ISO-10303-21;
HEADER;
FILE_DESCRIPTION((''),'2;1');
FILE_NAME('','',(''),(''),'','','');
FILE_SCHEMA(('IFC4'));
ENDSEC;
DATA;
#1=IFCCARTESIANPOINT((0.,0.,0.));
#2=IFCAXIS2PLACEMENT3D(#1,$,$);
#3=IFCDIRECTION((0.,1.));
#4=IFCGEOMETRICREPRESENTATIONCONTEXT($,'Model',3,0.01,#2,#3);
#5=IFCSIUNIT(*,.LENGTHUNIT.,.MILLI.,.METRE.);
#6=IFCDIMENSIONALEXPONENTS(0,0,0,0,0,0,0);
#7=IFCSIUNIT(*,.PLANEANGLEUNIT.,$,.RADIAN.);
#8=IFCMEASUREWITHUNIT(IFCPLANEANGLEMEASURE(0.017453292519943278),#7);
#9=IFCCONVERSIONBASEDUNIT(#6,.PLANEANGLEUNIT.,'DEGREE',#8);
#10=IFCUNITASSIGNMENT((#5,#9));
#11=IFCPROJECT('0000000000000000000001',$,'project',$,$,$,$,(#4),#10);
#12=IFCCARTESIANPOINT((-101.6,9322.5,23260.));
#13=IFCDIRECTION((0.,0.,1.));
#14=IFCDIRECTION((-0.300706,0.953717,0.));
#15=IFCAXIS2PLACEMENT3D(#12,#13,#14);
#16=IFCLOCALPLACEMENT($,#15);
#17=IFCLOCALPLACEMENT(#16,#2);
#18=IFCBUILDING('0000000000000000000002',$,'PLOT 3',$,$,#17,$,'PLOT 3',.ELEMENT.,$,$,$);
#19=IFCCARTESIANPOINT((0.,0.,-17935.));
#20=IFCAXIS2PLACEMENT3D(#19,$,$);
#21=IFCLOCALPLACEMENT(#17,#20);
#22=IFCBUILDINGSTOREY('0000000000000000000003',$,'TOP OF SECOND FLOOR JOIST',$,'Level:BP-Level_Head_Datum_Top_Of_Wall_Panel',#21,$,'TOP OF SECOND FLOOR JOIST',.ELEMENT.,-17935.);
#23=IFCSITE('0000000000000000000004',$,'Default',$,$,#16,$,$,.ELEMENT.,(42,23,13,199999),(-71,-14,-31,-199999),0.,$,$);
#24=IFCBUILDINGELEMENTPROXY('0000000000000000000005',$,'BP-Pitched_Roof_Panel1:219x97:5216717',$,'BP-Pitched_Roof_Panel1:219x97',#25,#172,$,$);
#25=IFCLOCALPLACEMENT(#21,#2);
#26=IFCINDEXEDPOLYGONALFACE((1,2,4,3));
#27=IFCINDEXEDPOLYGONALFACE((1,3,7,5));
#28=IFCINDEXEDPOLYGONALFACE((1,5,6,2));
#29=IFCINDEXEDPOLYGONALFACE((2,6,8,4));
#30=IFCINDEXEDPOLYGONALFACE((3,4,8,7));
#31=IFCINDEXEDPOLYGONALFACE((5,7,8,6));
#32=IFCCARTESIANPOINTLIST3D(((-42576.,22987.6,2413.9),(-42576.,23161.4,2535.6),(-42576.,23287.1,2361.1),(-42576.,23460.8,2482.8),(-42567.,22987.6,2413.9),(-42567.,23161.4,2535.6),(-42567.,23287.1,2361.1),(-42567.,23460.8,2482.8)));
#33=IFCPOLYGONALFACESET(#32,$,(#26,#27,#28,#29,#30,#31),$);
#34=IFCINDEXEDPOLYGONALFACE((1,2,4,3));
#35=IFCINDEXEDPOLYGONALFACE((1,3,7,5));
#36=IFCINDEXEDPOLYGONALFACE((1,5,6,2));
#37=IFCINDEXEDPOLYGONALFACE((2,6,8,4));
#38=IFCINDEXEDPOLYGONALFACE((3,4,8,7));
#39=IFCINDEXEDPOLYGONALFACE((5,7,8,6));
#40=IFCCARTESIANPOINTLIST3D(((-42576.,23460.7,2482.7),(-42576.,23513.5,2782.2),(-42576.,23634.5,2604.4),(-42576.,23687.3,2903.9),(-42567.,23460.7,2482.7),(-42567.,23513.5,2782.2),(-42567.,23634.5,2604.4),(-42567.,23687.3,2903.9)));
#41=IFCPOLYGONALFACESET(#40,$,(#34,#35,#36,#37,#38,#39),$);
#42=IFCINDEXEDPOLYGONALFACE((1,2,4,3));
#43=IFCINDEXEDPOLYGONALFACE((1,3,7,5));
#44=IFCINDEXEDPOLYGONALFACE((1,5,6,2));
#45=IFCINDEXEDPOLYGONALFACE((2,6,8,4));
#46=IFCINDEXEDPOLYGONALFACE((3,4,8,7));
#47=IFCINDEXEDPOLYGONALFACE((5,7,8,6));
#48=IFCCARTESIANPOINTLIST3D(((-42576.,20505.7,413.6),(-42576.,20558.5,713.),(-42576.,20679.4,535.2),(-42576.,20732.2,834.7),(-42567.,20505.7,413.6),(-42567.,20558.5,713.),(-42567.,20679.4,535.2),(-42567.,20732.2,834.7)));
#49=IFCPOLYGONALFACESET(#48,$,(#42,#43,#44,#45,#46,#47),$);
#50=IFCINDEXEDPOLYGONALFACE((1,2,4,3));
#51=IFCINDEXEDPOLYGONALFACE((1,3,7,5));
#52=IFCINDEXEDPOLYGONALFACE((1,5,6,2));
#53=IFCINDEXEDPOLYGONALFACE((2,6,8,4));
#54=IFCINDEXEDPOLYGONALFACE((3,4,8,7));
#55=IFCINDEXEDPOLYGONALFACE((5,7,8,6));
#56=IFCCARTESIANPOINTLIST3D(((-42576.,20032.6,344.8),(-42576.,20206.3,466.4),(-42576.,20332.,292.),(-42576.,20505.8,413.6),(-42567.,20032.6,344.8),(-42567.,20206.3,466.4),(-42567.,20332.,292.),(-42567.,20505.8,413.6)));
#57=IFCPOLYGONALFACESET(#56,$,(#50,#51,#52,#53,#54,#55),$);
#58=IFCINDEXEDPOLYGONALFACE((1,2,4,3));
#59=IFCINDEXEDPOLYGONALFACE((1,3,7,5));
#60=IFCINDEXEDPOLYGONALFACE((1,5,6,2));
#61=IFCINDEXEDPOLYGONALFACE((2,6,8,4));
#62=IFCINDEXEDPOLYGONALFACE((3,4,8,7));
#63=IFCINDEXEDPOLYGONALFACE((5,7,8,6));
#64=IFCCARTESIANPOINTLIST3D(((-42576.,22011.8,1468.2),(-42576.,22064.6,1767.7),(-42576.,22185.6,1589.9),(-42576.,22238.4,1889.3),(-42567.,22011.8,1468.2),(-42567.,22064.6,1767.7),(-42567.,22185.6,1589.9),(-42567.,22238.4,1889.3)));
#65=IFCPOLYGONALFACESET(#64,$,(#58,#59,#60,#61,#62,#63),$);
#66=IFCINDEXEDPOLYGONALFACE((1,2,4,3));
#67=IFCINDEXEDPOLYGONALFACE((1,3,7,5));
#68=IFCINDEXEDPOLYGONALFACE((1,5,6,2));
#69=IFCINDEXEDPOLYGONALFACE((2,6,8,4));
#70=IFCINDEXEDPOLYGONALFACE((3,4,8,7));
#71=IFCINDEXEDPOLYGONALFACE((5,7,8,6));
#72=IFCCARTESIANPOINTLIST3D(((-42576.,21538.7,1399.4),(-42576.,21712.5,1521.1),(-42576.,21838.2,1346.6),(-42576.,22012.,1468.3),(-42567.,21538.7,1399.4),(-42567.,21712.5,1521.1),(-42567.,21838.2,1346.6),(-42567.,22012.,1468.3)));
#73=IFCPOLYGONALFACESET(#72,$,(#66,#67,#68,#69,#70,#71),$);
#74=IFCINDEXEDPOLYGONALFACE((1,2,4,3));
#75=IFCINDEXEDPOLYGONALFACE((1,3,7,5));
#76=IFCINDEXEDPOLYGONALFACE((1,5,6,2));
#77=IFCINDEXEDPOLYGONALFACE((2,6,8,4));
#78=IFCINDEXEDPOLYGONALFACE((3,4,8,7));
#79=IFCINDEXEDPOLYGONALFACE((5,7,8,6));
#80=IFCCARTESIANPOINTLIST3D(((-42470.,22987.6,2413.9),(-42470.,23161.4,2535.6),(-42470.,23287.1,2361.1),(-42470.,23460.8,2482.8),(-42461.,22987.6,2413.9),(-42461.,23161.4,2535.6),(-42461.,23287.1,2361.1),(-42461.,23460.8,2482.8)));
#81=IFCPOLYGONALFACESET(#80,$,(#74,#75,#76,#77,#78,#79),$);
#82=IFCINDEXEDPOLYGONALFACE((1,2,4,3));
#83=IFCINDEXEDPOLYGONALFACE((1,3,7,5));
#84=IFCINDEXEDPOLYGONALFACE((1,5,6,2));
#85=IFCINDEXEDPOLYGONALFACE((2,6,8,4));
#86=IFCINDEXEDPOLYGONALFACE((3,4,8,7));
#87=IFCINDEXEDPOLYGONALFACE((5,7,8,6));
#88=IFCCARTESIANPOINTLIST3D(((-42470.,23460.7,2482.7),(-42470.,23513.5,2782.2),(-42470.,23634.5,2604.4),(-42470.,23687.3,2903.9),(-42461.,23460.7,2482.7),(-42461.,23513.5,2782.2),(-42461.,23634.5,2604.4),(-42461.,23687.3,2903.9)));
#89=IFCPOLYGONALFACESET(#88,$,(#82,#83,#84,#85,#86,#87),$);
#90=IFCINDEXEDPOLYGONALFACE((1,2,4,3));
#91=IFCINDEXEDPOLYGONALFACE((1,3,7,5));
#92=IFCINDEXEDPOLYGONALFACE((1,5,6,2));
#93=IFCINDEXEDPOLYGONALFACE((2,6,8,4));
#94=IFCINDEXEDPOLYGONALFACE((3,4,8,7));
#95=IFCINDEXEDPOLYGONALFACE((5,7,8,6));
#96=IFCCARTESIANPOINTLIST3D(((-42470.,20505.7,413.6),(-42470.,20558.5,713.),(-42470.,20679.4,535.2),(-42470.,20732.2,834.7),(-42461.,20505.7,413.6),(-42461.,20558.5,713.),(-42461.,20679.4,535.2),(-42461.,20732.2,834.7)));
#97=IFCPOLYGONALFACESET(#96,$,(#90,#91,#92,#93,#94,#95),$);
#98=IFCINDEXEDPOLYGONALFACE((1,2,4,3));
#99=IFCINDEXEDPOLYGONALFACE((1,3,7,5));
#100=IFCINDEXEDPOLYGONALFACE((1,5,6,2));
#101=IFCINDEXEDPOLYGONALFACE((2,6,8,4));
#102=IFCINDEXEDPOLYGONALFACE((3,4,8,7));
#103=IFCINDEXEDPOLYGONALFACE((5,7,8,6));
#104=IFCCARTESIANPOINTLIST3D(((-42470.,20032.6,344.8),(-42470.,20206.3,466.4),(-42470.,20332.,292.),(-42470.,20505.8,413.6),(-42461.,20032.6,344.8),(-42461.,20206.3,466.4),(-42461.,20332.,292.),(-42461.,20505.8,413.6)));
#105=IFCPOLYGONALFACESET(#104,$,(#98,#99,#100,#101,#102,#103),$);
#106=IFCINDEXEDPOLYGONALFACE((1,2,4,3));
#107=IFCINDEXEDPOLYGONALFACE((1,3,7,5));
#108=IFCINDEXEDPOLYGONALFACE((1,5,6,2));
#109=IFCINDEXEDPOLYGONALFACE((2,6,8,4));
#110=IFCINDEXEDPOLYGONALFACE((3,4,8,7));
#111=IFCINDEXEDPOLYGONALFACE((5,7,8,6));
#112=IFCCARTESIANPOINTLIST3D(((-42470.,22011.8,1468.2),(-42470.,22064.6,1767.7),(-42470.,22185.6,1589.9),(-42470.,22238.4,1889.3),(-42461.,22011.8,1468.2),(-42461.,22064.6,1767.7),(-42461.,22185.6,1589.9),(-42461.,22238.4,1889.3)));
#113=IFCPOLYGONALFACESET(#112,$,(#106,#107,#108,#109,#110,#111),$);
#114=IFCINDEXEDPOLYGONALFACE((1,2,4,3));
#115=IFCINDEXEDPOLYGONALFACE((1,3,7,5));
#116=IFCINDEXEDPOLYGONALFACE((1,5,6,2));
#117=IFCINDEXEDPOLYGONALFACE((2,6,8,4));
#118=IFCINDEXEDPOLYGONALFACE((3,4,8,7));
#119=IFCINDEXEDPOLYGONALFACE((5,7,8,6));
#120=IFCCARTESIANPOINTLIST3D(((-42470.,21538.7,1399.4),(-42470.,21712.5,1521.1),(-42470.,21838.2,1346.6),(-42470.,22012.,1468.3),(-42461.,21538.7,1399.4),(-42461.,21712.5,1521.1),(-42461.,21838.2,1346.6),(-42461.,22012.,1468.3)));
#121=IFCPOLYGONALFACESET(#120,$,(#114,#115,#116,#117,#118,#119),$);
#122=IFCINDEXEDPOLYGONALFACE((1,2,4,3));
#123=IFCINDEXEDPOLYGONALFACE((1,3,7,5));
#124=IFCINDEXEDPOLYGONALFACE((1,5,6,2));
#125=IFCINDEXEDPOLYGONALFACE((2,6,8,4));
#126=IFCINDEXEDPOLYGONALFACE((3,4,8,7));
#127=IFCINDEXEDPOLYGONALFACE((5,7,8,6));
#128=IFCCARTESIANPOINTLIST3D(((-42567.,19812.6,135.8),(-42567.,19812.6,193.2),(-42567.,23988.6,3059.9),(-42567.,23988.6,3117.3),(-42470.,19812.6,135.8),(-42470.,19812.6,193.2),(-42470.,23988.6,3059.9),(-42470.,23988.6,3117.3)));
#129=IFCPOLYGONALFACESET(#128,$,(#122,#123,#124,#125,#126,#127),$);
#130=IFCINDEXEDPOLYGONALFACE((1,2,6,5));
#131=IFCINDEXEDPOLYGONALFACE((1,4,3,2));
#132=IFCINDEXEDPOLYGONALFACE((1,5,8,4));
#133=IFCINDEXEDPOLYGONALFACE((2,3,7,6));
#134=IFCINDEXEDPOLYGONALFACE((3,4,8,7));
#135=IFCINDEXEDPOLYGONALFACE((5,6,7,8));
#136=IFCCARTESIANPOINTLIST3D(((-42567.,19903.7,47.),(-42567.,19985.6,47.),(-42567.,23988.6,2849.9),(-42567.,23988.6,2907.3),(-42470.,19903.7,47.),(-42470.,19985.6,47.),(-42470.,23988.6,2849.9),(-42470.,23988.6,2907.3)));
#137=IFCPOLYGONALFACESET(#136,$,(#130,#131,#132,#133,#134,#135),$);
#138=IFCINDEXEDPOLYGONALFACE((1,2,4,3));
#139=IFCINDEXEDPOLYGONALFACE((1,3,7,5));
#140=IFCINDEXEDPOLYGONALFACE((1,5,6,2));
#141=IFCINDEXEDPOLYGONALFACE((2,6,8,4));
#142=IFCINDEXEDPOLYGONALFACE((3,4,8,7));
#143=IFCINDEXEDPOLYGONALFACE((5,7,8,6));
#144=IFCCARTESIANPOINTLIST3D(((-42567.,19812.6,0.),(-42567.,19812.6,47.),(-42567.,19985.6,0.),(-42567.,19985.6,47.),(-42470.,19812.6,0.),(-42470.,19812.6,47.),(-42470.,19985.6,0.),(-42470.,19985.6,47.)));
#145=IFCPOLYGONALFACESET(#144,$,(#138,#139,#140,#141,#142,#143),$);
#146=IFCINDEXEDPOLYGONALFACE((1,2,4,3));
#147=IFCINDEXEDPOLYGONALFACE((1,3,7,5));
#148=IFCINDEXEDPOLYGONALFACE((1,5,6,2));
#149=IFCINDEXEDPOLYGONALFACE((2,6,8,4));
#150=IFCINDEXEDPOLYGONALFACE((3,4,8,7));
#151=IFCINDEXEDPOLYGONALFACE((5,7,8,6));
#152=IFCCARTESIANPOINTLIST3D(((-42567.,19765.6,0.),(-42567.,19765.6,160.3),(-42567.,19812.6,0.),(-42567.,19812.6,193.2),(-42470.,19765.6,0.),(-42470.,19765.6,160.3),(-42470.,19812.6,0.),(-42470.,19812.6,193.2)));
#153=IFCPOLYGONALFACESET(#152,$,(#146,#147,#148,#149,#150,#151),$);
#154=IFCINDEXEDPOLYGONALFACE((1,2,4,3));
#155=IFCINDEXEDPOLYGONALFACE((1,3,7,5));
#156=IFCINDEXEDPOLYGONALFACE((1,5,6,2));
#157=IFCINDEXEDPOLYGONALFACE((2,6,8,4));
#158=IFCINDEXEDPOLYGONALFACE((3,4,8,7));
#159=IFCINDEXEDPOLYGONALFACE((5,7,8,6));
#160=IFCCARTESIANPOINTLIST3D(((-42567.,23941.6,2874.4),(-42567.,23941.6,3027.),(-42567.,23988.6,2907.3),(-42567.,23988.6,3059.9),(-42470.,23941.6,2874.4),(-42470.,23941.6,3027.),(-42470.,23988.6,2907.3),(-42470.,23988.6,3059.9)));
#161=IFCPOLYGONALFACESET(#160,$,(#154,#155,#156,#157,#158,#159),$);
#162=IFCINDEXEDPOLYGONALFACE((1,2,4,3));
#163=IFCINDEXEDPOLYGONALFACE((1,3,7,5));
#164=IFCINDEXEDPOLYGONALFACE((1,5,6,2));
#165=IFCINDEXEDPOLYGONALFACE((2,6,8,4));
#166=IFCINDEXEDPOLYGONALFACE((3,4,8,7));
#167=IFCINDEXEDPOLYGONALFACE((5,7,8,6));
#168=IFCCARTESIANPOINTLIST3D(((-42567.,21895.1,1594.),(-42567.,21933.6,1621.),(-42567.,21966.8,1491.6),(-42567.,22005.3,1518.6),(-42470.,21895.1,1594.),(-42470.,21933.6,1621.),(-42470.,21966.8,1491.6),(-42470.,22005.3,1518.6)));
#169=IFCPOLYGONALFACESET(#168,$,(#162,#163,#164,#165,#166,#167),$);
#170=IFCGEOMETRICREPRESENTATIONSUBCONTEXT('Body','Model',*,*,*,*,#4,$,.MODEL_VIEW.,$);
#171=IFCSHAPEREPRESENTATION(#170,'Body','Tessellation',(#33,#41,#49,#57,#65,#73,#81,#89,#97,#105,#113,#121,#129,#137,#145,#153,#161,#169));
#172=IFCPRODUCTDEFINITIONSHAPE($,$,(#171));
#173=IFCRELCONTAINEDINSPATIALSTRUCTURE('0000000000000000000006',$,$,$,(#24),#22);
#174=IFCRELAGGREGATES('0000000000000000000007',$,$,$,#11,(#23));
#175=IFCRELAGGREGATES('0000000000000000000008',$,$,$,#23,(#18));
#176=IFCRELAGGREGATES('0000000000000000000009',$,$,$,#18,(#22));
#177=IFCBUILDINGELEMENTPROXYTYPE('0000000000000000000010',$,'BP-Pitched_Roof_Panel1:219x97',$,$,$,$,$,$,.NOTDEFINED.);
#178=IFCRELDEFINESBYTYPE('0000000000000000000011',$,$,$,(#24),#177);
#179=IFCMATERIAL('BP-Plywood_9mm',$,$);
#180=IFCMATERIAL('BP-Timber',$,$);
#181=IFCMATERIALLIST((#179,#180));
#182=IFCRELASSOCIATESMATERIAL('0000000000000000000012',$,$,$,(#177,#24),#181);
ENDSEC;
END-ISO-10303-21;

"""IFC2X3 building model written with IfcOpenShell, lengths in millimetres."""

from ifc_helpers import new_model, entity, si_unit, converted_unit, direction, frame, frame_2d, origin, origin_2d_with_axis, place, context, subcontext, project, spatial, polyline, rectangle, outline, extrude, source, transform, mapped, material, material_list, type_object, type_shapes, element, save


model = new_model("IFC2X3")

# Units and contexts
model_context = context("Model", 3, precision=0.01, world=origin(), true_north=direction((0.0, 1.0)))
body_context = subcontext(model_context, "Body", "Model", "MODEL_VIEW")
ifc_project = project(units=[si_unit("LENGTHUNIT", "METRE", prefix="MILLI"), converted_unit("PLANEANGLEUNIT", "DEGREE", entity("IfcPlaneAngleMeasure", 0.017453292519943278), si_unit("PLANEANGLEUNIT", "RADIAN"), dimensions=[0, 0, 0, 0, 0, 0, 0])], contexts=[model_context])

# Site, building, storey
site_placement = place(None, frame((-101.6, 9322.5, 23260.0), z_axis=(0.0, 0.0, 1.0), x_axis=(-0.300706, 0.953717, 0.0)))
site = spatial("IfcSite", under=ifc_project, at=site_placement, Name="Default", CompositionType="ELEMENT", RefLatitude=(42, 23, 13, 199999), RefLongitude=(-71, -14, -31, -199999), RefElevation=0.0)
building_placement = place(site_placement, origin())
building = spatial("IfcBuilding", under=site, at=building_placement, Name="PLOT 3", LongName="PLOT 3", CompositionType="ELEMENT")
storey_placement = place(building_placement, frame((0.0, 0.0, -17935.0)))
storey = spatial("IfcBuildingStorey", under=building, at=storey_placement, Name="TOP OF SECOND FLOOR JOIST", ObjectType="Level:BP-Level_Head_Datum_Top_Of_Wall_Panel", LongName="TOP OF SECOND FLOOR JOIST", CompositionType="ELEMENT", Elevation=-17935.0)

# Building element proxy
ifc_material_1 = material(Name="BP-Timber")
ifc_material_2 = material(Name="BP-Plywood_9mm")
ifc_material_list = material_list([ifc_material_2, ifc_material_1])
building_element_proxy_type_1 = type_object("IfcBuildingElementProxyType", Name="BP-Pitched_Roof_Panel1:219x97", PredefinedType="NOTDEFINED", material=ifc_material_list)
shared_shape_1 = source(origin(), body_context, "Body", "SweptSolid", [
    extrude(outline(polyline([(-77.0, -75.0), (227.0, -75.0), (77.0, 75.0), (-227.0, 75.0), (-77.0, -75.0)])), frame((36.3, 3947.0, 2448.4), z_axis=(0.0, 1.0, 0.0), x_axis=(-0.984808, 0.0, 0.173648)), (0.0, 0.0, 1.0), 9.0),
    extrude(outline(polyline([(1.4, -107.5), (213.6, -107.5), (-1.4, 107.5), (-213.6, 107.5), (1.4, -107.5)])), frame((386.1, 3947.0, 2693.3), z_axis=(0.0, 1.0, 0.0), x_axis=(-0.819152, 0.0, -0.573576)), (0.0, 0.0, 1.0), 9.0),
    extrude(outline(polyline([(1.4, -107.5), (213.6, -107.5), (-1.4, 107.5), (-213.6, 107.5), (1.4, -107.5)])), frame((-2569.0, 3947.0, 624.1), z_axis=(0.0, 1.0, 0.0), x_axis=(-0.819152, 0.0, -0.573576)), (0.0, 0.0, 1.0), 9.0),
    extrude(outline(polyline([(-77.0, -75.0), (227.0, -75.0), (77.0, 75.0), (-227.0, 75.0), (-77.0, -75.0)])), frame((-2918.8, 3947.0, 379.2), z_axis=(0.0, 1.0, 0.0), x_axis=(-0.984808, 0.0, 0.173648)), (0.0, 0.0, 1.0), 9.0),
    extrude(outline(polyline([(1.4, -107.5), (213.6, -107.5), (-1.4, 107.5), (-213.6, 107.5), (1.4, -107.5)])), frame((-1062.8, 3947.0, 1678.8), z_axis=(0.0, 1.0, 0.0), x_axis=(-0.819152, 0.0, -0.573576)), (0.0, 0.0, 1.0), 9.0),
    extrude(outline(polyline([(-77.0, -75.0), (227.0, -75.0), (77.0, 75.0), (-227.0, 75.0), (-77.0, -75.0)])), frame((-1412.6, 3947.0, 1433.9), z_axis=(0.0, 1.0, 0.0), x_axis=(-0.984808, 0.0, 0.173648)), (0.0, 0.0, 1.0), 9.0),
    extrude(outline(polyline([(-77.0, -75.0), (227.0, -75.0), (77.0, 75.0), (-227.0, 75.0), (-77.0, -75.0)])), frame((36.3, 3841.0, 2448.4), z_axis=(0.0, 1.0, 0.0), x_axis=(-0.984808, 0.0, 0.173648)), (0.0, 0.0, 1.0), 9.0),
    extrude(outline(polyline([(1.4, -107.5), (213.6, -107.5), (-1.4, 107.5), (-213.6, 107.5), (1.4, -107.5)])), frame((386.1, 3841.0, 2693.3), z_axis=(0.0, 1.0, 0.0), x_axis=(-0.819152, 0.0, -0.573576)), (0.0, 0.0, 1.0), 9.0),
    extrude(outline(polyline([(1.4, -107.5), (213.6, -107.5), (-1.4, 107.5), (-213.6, 107.5), (1.4, -107.5)])), frame((-2569.0, 3841.0, 624.1), z_axis=(0.0, 1.0, 0.0), x_axis=(-0.819152, 0.0, -0.573576)), (0.0, 0.0, 1.0), 9.0),
    extrude(outline(polyline([(-77.0, -75.0), (227.0, -75.0), (77.0, 75.0), (-227.0, 75.0), (-77.0, -75.0)])), frame((-2918.8, 3841.0, 379.2), z_axis=(0.0, 1.0, 0.0), x_axis=(-0.984808, 0.0, 0.173648)), (0.0, 0.0, 1.0), 9.0),
    extrude(outline(polyline([(1.4, -107.5), (213.6, -107.5), (-1.4, 107.5), (-213.6, 107.5), (1.4, -107.5)])), frame((-1062.8, 3841.0, 1678.8), z_axis=(0.0, 1.0, 0.0), x_axis=(-0.819152, 0.0, -0.573576)), (0.0, 0.0, 1.0), 9.0),
    extrude(outline(polyline([(-77.0, -75.0), (227.0, -75.0), (77.0, 75.0), (-227.0, 75.0), (-77.0, -75.0)])), frame((-1412.6, 3841.0, 1433.9), z_axis=(0.0, 1.0, 0.0), x_axis=(-0.984808, 0.0, 0.173648)), (0.0, 0.0, 1.0), 9.0),
    extrude(outline(polyline([(-1490.7, -2088.0), (-1433.3, -2088.0), (1490.7, 2088.0), (1433.3, 2088.0), (-1490.7, -2088.0)])), frame((-1287.3, 3850.0, 1626.6), z_axis=(0.0, 1.0, 0.0), x_axis=(0.0, 0.0, -1.0)), (0.0, 0.0, 1.0), 97.0),
    extrude(outline(polyline([(-1444.5, -2022.0), (-1387.1, -2022.0), (1415.8, 1981.0), (1415.8, 2063.0), (-1444.5, -2022.0)])), frame((-1221.3, 3850.0, 1462.8), z_axis=(0.0, 1.0, 0.0), x_axis=(0.0, 0.0, -1.0)), (0.0, 0.0, 1.0), 97.0),
    extrude(rectangle(XDim=97.0, YDim=173.0, at=origin_2d_with_axis()), frame((-3288.8, 3898.5, 0.0), z_axis=(0.0, 0.0, 1.0), x_axis=(0.0, 1.0, 0.0)), (0.0, 0.0, 1.0), 47.0),
    extrude(outline(polyline([(22.0, -72.4), (79.4, -72.4), (-31.4, 85.9), (-69.9, 58.9), (22.0, -72.4)])), frame((-3398.8, 3850.0, 88.4), z_axis=(0.0, 1.0, 0.0), x_axis=(0.819152, 0.0, 0.573576)), (0.0, 0.0, 1.0), 97.0),
    extrude(outline(polyline([(15.1, -62.5), (72.5, -62.5), (-15.1, 62.5), (-72.5, 62.5), (15.1, -62.5)])), frame((777.2, 3850.0, 2967.2), z_axis=(0.0, 1.0, 0.0), x_axis=(0.819152, 0.0, 0.573576)), (0.0, 0.0, 1.0), 97.0),
    extrude(rectangle(XDim=47.0, YDim=97.0, at=frame_2d((0.0, 0.0), x_axis=(0.0, 1.0))), frame((-1201.9, 3898.5, 1505.1), z_axis=(-0.573576, 0.0, 0.819152), x_axis=(0.0, 1.0, 0.0)), (0.0, 0.0, 1.0), 125.0),
])
type_shapes(building_element_proxy_type_1, [shared_shape_1])
for number, where, z_axis, x_axis, name in (
    (1, (-38620.0, 23187.9, 0.0), (0.0, 0.0, 1.0), (0.0, 1.0, 0.0), "BP-Pitched_Roof_Panel1:219x97:5216717"),
):
    element("IfcBuildingElementProxy", number, at=place(storey_placement, frame(where, z_axis=z_axis, x_axis=x_axis)), inside=storey, type_object=building_element_proxy_type_1, material=ifc_material_list, Name=name, ObjectType="BP-Pitched_Roof_Panel1:219x97", context=body_context, shape_type="MappedRepresentation", body=[
        mapped(shared_shape_1, transform((0.0, 0.0, 0.0), scale=1.0)),
    ])

save(model, "model.ifc")
